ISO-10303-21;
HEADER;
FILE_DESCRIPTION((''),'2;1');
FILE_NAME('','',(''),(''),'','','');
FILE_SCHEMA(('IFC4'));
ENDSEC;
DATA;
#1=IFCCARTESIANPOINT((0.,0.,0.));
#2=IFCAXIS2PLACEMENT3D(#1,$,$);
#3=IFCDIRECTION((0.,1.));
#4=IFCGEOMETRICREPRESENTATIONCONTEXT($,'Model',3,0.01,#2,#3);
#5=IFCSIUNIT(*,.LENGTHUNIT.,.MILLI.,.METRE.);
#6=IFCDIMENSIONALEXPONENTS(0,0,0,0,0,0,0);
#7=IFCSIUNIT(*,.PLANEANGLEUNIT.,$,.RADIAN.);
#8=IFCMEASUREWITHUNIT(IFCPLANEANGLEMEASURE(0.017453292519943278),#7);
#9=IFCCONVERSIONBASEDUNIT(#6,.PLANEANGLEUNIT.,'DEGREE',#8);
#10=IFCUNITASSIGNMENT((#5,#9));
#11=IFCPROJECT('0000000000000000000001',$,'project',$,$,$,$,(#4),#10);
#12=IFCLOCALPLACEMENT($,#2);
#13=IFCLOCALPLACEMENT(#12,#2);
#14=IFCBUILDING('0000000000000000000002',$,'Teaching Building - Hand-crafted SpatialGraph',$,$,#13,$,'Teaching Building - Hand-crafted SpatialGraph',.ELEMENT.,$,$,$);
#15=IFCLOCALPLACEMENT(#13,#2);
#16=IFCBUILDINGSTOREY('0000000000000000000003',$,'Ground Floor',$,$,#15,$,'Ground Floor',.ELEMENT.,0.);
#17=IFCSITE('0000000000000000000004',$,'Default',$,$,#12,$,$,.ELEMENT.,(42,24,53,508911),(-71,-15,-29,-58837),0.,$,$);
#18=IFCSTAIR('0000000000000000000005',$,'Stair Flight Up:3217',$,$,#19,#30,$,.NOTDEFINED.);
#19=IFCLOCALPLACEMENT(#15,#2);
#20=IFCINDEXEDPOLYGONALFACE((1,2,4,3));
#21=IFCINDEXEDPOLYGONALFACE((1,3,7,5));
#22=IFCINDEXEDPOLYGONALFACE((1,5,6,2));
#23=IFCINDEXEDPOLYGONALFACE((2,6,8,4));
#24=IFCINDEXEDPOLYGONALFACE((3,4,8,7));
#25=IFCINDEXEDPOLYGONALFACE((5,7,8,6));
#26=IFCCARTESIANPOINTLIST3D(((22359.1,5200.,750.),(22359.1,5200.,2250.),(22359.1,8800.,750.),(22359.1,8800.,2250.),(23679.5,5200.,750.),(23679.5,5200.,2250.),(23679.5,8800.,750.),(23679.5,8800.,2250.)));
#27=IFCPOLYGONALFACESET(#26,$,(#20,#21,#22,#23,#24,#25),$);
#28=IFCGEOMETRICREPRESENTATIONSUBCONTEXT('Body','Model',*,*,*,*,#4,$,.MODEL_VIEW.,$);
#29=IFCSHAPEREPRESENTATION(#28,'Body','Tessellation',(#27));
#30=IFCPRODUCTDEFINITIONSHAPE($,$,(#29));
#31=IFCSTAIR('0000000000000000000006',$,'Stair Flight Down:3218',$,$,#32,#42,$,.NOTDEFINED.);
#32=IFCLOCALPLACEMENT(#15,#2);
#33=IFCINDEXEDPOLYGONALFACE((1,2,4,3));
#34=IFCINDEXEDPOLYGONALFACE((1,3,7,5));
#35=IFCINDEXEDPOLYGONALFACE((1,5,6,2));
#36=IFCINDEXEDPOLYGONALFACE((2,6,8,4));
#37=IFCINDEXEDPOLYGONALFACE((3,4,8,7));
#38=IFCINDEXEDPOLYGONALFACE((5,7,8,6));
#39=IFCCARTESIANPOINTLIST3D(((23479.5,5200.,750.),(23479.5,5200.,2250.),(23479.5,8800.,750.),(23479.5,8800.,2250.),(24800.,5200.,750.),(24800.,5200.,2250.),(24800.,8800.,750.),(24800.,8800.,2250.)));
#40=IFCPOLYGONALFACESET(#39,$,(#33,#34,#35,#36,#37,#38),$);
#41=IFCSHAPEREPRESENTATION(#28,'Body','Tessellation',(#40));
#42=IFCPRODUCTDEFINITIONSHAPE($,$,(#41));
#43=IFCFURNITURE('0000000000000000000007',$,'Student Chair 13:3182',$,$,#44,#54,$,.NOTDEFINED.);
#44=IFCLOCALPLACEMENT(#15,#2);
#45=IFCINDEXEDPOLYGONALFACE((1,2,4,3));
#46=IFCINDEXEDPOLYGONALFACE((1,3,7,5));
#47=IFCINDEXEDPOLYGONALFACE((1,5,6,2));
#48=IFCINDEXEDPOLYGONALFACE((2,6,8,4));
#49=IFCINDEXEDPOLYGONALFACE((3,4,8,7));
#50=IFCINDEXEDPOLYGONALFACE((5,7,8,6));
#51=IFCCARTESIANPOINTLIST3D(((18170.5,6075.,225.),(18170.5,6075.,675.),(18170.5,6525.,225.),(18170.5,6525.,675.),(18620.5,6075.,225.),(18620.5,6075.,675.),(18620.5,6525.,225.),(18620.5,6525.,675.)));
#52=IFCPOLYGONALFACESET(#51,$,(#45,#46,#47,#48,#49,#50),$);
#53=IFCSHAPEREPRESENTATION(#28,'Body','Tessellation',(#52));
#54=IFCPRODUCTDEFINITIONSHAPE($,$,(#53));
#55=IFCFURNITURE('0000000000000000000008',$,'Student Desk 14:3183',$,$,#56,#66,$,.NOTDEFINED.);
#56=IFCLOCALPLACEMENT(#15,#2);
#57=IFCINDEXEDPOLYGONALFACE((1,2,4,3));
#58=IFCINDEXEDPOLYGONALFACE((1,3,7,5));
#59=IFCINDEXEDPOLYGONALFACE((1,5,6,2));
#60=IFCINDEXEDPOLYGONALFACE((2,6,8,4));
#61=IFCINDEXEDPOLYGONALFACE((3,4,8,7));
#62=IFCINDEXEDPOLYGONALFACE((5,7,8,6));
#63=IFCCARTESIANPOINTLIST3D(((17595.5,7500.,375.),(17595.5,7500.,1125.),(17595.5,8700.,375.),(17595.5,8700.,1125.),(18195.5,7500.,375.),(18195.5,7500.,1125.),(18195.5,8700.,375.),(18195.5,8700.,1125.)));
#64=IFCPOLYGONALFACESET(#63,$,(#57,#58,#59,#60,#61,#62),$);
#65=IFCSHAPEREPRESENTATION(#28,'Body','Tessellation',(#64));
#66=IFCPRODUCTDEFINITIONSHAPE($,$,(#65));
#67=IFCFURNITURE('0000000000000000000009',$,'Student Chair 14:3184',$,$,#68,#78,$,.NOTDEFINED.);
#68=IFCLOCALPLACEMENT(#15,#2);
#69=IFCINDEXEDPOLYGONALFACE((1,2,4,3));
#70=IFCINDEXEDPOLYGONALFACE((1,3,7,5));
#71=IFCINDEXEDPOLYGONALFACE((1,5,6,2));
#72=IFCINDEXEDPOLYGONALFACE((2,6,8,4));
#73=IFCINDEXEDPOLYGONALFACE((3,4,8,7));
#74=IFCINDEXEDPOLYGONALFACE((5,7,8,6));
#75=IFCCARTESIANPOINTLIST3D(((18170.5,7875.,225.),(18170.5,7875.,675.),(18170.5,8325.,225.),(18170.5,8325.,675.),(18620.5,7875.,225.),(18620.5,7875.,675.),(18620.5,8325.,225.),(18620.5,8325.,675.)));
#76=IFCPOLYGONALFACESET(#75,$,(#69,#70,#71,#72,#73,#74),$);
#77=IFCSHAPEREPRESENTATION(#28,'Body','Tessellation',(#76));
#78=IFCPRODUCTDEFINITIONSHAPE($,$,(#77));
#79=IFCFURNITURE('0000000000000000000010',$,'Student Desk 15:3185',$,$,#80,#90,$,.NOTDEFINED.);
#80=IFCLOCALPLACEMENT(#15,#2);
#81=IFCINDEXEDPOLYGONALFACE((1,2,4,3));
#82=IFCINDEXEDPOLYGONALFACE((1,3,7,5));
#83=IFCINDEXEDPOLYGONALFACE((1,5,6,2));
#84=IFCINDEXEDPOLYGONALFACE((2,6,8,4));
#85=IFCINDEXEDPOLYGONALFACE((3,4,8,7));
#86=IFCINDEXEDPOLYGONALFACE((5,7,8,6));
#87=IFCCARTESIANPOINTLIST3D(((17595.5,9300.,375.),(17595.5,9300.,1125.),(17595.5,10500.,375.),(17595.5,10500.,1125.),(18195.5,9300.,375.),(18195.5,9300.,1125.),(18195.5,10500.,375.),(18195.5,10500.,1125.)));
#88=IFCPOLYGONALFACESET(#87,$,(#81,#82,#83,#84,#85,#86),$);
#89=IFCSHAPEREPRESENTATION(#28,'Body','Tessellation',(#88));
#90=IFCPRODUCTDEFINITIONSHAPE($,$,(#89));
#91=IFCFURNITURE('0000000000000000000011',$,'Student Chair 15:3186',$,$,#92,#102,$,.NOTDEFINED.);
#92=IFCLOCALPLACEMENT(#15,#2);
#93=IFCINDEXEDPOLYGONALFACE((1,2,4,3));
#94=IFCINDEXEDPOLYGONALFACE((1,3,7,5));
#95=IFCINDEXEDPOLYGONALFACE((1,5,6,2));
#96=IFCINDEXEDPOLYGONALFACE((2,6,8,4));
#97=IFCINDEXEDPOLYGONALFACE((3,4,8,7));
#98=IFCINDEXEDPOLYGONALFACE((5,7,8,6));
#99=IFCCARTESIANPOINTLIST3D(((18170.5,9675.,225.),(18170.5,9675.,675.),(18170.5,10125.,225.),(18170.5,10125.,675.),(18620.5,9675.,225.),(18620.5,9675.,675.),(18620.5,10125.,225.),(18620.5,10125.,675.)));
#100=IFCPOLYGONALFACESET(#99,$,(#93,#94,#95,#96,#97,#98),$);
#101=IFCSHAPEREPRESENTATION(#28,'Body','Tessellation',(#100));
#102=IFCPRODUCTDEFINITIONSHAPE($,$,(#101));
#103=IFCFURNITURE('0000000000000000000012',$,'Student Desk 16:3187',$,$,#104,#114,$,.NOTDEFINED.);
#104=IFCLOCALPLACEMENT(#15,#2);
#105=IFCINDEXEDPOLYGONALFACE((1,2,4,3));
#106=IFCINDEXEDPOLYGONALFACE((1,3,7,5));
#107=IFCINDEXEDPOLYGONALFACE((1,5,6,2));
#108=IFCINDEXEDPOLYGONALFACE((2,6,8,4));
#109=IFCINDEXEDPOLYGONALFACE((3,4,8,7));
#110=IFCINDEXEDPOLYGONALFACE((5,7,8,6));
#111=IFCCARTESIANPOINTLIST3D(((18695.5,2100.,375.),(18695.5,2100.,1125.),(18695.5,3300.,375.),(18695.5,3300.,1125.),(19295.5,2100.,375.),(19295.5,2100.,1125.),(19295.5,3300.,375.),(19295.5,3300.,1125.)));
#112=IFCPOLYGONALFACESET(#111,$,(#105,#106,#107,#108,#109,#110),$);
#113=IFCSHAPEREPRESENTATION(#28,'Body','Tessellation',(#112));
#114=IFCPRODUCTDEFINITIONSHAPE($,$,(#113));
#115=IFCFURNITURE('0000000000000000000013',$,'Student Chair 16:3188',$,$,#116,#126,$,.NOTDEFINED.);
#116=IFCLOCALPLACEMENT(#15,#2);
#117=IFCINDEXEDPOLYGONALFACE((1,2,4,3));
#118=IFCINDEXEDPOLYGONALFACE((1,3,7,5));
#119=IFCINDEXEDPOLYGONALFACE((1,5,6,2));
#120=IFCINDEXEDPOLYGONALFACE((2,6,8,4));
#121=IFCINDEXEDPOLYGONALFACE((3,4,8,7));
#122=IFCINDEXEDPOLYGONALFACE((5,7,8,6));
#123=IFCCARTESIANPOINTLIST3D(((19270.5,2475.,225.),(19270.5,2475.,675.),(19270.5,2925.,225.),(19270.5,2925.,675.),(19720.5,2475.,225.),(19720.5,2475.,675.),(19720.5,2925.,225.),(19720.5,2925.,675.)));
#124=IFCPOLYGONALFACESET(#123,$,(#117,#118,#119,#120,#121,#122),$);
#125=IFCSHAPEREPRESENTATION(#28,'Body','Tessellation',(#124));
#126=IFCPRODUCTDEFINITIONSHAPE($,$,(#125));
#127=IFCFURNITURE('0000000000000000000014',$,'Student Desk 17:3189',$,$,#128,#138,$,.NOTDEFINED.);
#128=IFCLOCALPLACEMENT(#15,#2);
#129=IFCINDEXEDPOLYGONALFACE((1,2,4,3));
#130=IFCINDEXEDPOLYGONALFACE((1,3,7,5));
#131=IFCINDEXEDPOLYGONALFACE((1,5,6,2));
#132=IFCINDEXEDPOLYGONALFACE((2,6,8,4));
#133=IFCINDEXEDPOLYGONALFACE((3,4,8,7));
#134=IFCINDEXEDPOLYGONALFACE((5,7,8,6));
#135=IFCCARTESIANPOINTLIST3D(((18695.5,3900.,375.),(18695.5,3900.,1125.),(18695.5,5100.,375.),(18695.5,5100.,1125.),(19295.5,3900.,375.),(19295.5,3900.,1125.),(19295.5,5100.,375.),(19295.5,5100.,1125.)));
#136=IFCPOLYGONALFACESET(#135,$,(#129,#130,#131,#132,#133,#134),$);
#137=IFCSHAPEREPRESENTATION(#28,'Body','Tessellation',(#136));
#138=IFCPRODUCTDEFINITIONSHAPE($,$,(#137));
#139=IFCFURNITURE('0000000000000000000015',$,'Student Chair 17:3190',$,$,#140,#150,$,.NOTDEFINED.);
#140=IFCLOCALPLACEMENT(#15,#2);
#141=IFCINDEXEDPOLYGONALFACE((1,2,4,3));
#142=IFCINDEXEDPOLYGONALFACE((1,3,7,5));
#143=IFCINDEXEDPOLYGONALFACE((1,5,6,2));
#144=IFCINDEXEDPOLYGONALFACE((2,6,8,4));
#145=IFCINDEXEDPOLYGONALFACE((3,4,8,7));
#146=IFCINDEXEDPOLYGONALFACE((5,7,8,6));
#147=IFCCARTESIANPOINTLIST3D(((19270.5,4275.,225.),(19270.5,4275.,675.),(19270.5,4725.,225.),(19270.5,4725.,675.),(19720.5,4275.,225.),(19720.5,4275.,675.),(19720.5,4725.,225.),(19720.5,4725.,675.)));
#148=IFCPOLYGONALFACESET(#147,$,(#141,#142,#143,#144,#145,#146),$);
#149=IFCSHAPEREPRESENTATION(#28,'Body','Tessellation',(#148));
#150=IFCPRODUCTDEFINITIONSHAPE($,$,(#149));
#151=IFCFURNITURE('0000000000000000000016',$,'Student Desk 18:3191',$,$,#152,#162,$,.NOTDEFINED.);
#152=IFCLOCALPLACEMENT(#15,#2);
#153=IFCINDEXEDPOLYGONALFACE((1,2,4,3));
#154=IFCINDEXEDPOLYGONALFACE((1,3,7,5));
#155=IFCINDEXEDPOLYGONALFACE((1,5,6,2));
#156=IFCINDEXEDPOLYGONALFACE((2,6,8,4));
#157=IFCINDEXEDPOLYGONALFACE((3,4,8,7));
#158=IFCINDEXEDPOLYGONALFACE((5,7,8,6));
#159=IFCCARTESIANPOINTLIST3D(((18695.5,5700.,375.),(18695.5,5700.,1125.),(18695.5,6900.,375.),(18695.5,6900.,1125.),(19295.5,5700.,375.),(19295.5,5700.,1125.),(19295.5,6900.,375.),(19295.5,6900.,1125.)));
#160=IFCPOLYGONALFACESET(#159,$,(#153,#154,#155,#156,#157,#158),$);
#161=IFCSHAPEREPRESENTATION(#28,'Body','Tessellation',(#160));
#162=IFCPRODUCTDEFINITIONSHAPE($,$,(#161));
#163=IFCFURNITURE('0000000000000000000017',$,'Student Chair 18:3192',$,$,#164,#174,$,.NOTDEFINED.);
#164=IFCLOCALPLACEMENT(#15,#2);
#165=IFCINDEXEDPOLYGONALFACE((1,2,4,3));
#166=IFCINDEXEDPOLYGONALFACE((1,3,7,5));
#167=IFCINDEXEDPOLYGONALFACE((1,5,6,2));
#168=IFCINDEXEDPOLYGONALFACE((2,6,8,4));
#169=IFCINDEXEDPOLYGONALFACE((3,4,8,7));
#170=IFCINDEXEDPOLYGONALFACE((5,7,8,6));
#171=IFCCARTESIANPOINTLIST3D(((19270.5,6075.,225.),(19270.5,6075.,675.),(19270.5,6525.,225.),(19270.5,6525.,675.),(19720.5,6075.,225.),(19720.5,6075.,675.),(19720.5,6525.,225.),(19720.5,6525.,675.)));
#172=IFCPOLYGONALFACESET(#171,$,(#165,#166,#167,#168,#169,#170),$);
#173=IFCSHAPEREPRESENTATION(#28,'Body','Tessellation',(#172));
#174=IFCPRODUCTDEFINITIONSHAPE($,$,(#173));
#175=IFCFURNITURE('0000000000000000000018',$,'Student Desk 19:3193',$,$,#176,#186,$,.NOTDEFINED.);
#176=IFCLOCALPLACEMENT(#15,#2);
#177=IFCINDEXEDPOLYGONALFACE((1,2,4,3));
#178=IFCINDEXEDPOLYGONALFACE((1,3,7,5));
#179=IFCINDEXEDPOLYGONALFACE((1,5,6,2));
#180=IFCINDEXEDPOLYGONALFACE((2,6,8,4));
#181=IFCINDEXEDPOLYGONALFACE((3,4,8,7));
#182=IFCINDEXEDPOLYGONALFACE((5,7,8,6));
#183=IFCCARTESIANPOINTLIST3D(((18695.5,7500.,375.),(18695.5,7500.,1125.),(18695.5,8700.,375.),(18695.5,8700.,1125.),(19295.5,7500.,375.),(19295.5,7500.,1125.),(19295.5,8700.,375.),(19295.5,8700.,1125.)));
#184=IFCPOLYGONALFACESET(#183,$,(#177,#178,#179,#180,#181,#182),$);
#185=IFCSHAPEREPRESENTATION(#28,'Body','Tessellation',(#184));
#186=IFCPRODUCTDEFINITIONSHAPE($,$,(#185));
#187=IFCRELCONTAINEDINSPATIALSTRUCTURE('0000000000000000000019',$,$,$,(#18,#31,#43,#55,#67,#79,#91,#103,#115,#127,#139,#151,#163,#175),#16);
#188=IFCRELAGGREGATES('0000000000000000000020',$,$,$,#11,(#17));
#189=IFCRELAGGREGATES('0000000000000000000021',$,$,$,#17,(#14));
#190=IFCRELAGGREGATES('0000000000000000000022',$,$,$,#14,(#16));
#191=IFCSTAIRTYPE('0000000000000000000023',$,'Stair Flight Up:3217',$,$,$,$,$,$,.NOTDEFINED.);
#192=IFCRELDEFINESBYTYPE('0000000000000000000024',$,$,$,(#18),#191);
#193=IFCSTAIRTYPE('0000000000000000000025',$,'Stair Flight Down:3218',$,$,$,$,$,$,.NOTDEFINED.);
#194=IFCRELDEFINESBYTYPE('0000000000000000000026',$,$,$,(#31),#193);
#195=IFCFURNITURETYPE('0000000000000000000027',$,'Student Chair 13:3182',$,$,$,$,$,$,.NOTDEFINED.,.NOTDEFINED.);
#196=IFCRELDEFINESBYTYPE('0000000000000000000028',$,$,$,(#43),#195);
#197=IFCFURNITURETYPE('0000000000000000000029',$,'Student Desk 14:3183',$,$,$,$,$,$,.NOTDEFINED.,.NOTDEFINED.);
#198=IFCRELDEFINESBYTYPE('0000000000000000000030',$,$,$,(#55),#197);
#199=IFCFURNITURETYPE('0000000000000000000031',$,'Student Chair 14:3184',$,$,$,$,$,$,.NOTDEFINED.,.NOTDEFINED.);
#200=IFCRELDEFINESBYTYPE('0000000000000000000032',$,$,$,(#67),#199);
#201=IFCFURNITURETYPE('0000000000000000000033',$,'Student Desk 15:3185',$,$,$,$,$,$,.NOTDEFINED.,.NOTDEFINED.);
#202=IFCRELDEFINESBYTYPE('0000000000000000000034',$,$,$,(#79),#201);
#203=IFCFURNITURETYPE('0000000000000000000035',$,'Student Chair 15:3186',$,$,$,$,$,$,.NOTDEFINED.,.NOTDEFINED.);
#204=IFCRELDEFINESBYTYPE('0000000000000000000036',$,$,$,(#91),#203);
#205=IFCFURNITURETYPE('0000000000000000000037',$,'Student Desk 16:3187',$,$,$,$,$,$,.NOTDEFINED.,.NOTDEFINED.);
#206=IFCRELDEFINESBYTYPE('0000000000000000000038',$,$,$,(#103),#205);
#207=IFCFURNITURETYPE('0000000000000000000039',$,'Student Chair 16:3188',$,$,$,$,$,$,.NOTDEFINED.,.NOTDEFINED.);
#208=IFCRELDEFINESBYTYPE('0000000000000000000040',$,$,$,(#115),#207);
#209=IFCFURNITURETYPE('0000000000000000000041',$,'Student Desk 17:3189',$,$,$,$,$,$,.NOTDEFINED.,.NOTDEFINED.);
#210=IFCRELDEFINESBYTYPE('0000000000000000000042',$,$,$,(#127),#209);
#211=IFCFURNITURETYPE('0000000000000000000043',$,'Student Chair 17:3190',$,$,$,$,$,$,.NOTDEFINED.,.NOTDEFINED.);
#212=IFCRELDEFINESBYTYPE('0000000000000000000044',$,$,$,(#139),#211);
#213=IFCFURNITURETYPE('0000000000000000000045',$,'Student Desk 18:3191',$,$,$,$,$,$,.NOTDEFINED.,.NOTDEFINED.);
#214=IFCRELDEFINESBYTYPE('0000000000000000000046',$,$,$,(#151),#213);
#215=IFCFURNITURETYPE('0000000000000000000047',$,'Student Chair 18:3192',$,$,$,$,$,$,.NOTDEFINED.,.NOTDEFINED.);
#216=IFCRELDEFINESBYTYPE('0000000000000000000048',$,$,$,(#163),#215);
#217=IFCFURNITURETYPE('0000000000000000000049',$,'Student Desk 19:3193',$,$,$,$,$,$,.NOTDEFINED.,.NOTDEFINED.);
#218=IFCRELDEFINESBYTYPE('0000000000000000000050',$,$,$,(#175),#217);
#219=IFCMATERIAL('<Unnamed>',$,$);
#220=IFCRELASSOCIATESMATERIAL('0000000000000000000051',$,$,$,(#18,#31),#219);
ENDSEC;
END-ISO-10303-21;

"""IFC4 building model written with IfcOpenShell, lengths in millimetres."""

from ifc_helpers import new_model, entity, si_unit, converted_unit, direction, frame, frame_2d, origin, origin_2d_with_axis, place, context, subcontext, project, spatial, rectangle, extrude, material, type_object, element, save


model = new_model("IFC4")

# Units and contexts
model_context = context("Model", 3, precision=0.01, world=origin(), true_north=direction((0.0, 1.0)))
body_context = subcontext(model_context, "Body", "Model", "MODEL_VIEW")
ifc_project = project(units=[si_unit("LENGTHUNIT", "METRE", prefix="MILLI"), converted_unit("PLANEANGLEUNIT", "DEGREE", entity("IfcPlaneAngleMeasure", 0.017453292519943278), si_unit("PLANEANGLEUNIT", "RADIAN"), dimensions=[0, 0, 0, 0, 0, 0, 0])], contexts=[model_context])

# Site, building, storey
site_placement = place(None, origin())
site = spatial("IfcSite", under=ifc_project, at=site_placement, Name="Default", CompositionType="ELEMENT", RefLatitude=(42, 24, 53, 508911), RefLongitude=(-71, -15, -29, -58837), RefElevation=0.0)
building_placement = place(site_placement, origin())
building = spatial("IfcBuilding", under=site, at=building_placement, Name="Teaching Building - Hand-crafted SpatialGraph", LongName="Teaching Building - Hand-crafted SpatialGraph", CompositionType="ELEMENT")
storey_placement = place(building_placement, origin())
storey = spatial("IfcBuildingStorey", under=building, at=storey_placement, Name="Ground Floor", LongName="Ground Floor", CompositionType="ELEMENT", Elevation=0.0)

# Stairs
ifc_material = material(Name="<Unnamed>")
stair_type_1 = type_object("IfcStairType", Name="Stair Flight Up:3217", PredefinedType="NOTDEFINED")
stair_1_placement = place(storey_placement, origin())
element("IfcStair", 1, at=stair_1_placement, inside=storey, type_object=stair_type_1, material=ifc_material, Name="Stair Flight Up:3217", PredefinedType="NOTDEFINED", context=body_context, shape_type="SweptSolid", body=[
    extrude(rectangle(XDim=1320.5, YDim=3600.0, at=origin_2d_with_axis()), frame((23019.3, 7000.0, 750.0)), (0.0, 0.0, 1.0), 1500.0),
])
stair_type_2 = type_object("IfcStairType", Name="Stair Flight Down:3218", PredefinedType="NOTDEFINED")
stair_2_placement = place(storey_placement, origin())
element("IfcStair", 2, at=stair_2_placement, inside=storey, type_object=stair_type_2, material=ifc_material, Name="Stair Flight Down:3218", PredefinedType="NOTDEFINED", context=body_context, shape_type="SweptSolid", body=[
    extrude(rectangle(XDim=1320.5, YDim=3600.0, at=origin_2d_with_axis()), frame((24139.8, 7000.0, 750.0)), (0.0, 0.0, 1.0), 1500.0),
])

# Furniture
furniture_type_1 = type_object("IfcFurnitureType", Name="Student Chair 13:3182", PredefinedType="NOTDEFINED")
furniture_1_placement = place(storey_placement, origin())
element("IfcFurniture", 3, at=furniture_1_placement, inside=storey, type_object=furniture_type_1, Name="Student Chair 13:3182", PredefinedType="NOTDEFINED", context=body_context, shape_type="SweptSolid", body=[
    extrude(rectangle(XDim=450.0, YDim=450.0, at=origin_2d_with_axis()), frame((18395.5, 6300.0, 225.0)), (0.0, 0.0, 1.0), 450.0),
])
furniture_type_2 = type_object("IfcFurnitureType", Name="Student Desk 14:3183", PredefinedType="NOTDEFINED")
furniture_2_placement = place(storey_placement, origin())
element("IfcFurniture", 4, at=furniture_2_placement, inside=storey, type_object=furniture_type_2, Name="Student Desk 14:3183", PredefinedType="NOTDEFINED", context=body_context, shape_type="SweptSolid", body=[
    extrude(rectangle(XDim=1200.0, YDim=600.0, at=origin_2d_with_axis()), frame((17895.5, 8100.0, 375.0), z_axis=(0.0, 0.0, 1.0), x_axis=(0.0, 1.0, 0.0)), (0.0, 0.0, 1.0), 750.0),
])
furniture_type_3 = type_object("IfcFurnitureType", Name="Student Chair 14:3184", PredefinedType="NOTDEFINED")
furniture_3_placement = place(storey_placement, origin())
element("IfcFurniture", 5, at=furniture_3_placement, inside=storey, type_object=furniture_type_3, Name="Student Chair 14:3184", PredefinedType="NOTDEFINED", context=body_context, shape_type="SweptSolid", body=[
    extrude(rectangle(XDim=450.0, YDim=450.0, at=origin_2d_with_axis()), frame((18395.5, 8100.0, 225.0)), (0.0, 0.0, 1.0), 450.0),
])
furniture_type_4 = type_object("IfcFurnitureType", Name="Student Desk 15:3185", PredefinedType="NOTDEFINED")
furniture_4_placement = place(storey_placement, origin())
element("IfcFurniture", 6, at=furniture_4_placement, inside=storey, type_object=furniture_type_4, Name="Student Desk 15:3185", PredefinedType="NOTDEFINED", context=body_context, shape_type="SweptSolid", body=[
    extrude(rectangle(XDim=1200.0, YDim=600.0, at=origin_2d_with_axis()), frame((17895.5, 9900.0, 375.0), z_axis=(0.0, 0.0, 1.0), x_axis=(0.0, 1.0, 0.0)), (0.0, 0.0, 1.0), 750.0),
])
furniture_type_5 = type_object("IfcFurnitureType", Name="Student Chair 15:3186", PredefinedType="NOTDEFINED")
furniture_5_placement = place(storey_placement, origin())
element("IfcFurniture", 7, at=furniture_5_placement, inside=storey, type_object=furniture_type_5, Name="Student Chair 15:3186", PredefinedType="NOTDEFINED", context=body_context, shape_type="SweptSolid", body=[
    extrude(rectangle(XDim=450.0, YDim=450.0, at=frame_2d((0.0, 0.0), x_axis=(1.0, 0.0))), frame((18395.5, 9900.0, 225.0)), (0.0, 0.0, 1.0), 450.0),
])
furniture_type_6 = type_object("IfcFurnitureType", Name="Student Desk 16:3187", PredefinedType="NOTDEFINED")
furniture_6_placement = place(storey_placement, origin())
element("IfcFurniture", 8, at=furniture_6_placement, inside=storey, type_object=furniture_type_6, Name="Student Desk 16:3187", PredefinedType="NOTDEFINED", context=body_context, shape_type="SweptSolid", body=[
    extrude(rectangle(XDim=1200.0, YDim=600.0, at=origin_2d_with_axis()), frame((18995.5, 2700.0, 375.0), z_axis=(0.0, 0.0, 1.0), x_axis=(0.0, 1.0, 0.0)), (0.0, 0.0, 1.0), 750.0),
])
furniture_type_7 = type_object("IfcFurnitureType", Name="Student Chair 16:3188", PredefinedType="NOTDEFINED")
furniture_7_placement = place(storey_placement, origin())
element("IfcFurniture", 9, at=furniture_7_placement, inside=storey, type_object=furniture_type_7, Name="Student Chair 16:3188", PredefinedType="NOTDEFINED", context=body_context, shape_type="SweptSolid", body=[
    extrude(rectangle(XDim=450.0, YDim=450.0, at=origin_2d_with_axis()), frame((19495.5, 2700.0, 225.0)), (0.0, 0.0, 1.0), 450.0),
])
furniture_type_8 = type_object("IfcFurnitureType", Name="Student Desk 17:3189", PredefinedType="NOTDEFINED")
furniture_8_placement = place(storey_placement, origin())
element("IfcFurniture", 10, at=furniture_8_placement, inside=storey, type_object=furniture_type_8, Name="Student Desk 17:3189", PredefinedType="NOTDEFINED", context=body_context, shape_type="SweptSolid", body=[
    extrude(rectangle(XDim=1200.0, YDim=600.0, at=frame_2d((0.0, 0.0), x_axis=(1.0, 0.0))), frame((18995.5, 4500.0, 375.0), z_axis=(0.0, 0.0, 1.0), x_axis=(0.0, 1.0, 0.0)), (0.0, 0.0, 1.0), 750.0),
])
furniture_type_9 = type_object("IfcFurnitureType", Name="Student Chair 17:3190", PredefinedType="NOTDEFINED")
furniture_9_placement = place(storey_placement, origin())
element("IfcFurniture", 11, at=furniture_9_placement, inside=storey, type_object=furniture_type_9, Name="Student Chair 17:3190", PredefinedType="NOTDEFINED", context=body_context, shape_type="SweptSolid", body=[
    extrude(rectangle(XDim=450.0, YDim=450.0, at=origin_2d_with_axis()), frame((19495.5, 4500.0, 225.0)), (0.0, 0.0, 1.0), 450.0),
])
furniture_type_10 = type_object("IfcFurnitureType", Name="Student Desk 18:3191", PredefinedType="NOTDEFINED")
furniture_10_placement = place(storey_placement, origin())
element("IfcFurniture", 12, at=furniture_10_placement, inside=storey, type_object=furniture_type_10, Name="Student Desk 18:3191", PredefinedType="NOTDEFINED", context=body_context, shape_type="SweptSolid", body=[
    extrude(rectangle(XDim=1200.0, YDim=600.0, at=origin_2d_with_axis()), frame((18995.5, 6300.0, 375.0), z_axis=(0.0, 0.0, 1.0), x_axis=(0.0, 1.0, 0.0)), (0.0, 0.0, 1.0), 750.0),
])
furniture_type_11 = type_object("IfcFurnitureType", Name="Student Chair 18:3192", PredefinedType="NOTDEFINED")
furniture_11_placement = place(storey_placement, origin())
element("IfcFurniture", 13, at=furniture_11_placement, inside=storey, type_object=furniture_type_11, Name="Student Chair 18:3192", PredefinedType="NOTDEFINED", context=body_context, shape_type="SweptSolid", body=[
    extrude(rectangle(XDim=450.0, YDim=450.0, at=origin_2d_with_axis()), frame((19495.5, 6300.0, 225.0)), (0.0, 0.0, 1.0), 450.0),
])
furniture_type_12 = type_object("IfcFurnitureType", Name="Student Desk 19:3193", PredefinedType="NOTDEFINED")
furniture_12_placement = place(storey_placement, origin())
element("IfcFurniture", 14, at=furniture_12_placement, inside=storey, type_object=furniture_type_12, Name="Student Desk 19:3193", PredefinedType="NOTDEFINED", context=body_context, shape_type="SweptSolid", body=[
    extrude(rectangle(XDim=1200.0, YDim=600.0, at=origin_2d_with_axis()), frame((18995.5, 8100.0, 375.0), z_axis=(0.0, 0.0, 1.0), x_axis=(0.0, 1.0, 0.0)), (0.0, 0.0, 1.0), 750.0),
])

save(model, "model.ifc")
